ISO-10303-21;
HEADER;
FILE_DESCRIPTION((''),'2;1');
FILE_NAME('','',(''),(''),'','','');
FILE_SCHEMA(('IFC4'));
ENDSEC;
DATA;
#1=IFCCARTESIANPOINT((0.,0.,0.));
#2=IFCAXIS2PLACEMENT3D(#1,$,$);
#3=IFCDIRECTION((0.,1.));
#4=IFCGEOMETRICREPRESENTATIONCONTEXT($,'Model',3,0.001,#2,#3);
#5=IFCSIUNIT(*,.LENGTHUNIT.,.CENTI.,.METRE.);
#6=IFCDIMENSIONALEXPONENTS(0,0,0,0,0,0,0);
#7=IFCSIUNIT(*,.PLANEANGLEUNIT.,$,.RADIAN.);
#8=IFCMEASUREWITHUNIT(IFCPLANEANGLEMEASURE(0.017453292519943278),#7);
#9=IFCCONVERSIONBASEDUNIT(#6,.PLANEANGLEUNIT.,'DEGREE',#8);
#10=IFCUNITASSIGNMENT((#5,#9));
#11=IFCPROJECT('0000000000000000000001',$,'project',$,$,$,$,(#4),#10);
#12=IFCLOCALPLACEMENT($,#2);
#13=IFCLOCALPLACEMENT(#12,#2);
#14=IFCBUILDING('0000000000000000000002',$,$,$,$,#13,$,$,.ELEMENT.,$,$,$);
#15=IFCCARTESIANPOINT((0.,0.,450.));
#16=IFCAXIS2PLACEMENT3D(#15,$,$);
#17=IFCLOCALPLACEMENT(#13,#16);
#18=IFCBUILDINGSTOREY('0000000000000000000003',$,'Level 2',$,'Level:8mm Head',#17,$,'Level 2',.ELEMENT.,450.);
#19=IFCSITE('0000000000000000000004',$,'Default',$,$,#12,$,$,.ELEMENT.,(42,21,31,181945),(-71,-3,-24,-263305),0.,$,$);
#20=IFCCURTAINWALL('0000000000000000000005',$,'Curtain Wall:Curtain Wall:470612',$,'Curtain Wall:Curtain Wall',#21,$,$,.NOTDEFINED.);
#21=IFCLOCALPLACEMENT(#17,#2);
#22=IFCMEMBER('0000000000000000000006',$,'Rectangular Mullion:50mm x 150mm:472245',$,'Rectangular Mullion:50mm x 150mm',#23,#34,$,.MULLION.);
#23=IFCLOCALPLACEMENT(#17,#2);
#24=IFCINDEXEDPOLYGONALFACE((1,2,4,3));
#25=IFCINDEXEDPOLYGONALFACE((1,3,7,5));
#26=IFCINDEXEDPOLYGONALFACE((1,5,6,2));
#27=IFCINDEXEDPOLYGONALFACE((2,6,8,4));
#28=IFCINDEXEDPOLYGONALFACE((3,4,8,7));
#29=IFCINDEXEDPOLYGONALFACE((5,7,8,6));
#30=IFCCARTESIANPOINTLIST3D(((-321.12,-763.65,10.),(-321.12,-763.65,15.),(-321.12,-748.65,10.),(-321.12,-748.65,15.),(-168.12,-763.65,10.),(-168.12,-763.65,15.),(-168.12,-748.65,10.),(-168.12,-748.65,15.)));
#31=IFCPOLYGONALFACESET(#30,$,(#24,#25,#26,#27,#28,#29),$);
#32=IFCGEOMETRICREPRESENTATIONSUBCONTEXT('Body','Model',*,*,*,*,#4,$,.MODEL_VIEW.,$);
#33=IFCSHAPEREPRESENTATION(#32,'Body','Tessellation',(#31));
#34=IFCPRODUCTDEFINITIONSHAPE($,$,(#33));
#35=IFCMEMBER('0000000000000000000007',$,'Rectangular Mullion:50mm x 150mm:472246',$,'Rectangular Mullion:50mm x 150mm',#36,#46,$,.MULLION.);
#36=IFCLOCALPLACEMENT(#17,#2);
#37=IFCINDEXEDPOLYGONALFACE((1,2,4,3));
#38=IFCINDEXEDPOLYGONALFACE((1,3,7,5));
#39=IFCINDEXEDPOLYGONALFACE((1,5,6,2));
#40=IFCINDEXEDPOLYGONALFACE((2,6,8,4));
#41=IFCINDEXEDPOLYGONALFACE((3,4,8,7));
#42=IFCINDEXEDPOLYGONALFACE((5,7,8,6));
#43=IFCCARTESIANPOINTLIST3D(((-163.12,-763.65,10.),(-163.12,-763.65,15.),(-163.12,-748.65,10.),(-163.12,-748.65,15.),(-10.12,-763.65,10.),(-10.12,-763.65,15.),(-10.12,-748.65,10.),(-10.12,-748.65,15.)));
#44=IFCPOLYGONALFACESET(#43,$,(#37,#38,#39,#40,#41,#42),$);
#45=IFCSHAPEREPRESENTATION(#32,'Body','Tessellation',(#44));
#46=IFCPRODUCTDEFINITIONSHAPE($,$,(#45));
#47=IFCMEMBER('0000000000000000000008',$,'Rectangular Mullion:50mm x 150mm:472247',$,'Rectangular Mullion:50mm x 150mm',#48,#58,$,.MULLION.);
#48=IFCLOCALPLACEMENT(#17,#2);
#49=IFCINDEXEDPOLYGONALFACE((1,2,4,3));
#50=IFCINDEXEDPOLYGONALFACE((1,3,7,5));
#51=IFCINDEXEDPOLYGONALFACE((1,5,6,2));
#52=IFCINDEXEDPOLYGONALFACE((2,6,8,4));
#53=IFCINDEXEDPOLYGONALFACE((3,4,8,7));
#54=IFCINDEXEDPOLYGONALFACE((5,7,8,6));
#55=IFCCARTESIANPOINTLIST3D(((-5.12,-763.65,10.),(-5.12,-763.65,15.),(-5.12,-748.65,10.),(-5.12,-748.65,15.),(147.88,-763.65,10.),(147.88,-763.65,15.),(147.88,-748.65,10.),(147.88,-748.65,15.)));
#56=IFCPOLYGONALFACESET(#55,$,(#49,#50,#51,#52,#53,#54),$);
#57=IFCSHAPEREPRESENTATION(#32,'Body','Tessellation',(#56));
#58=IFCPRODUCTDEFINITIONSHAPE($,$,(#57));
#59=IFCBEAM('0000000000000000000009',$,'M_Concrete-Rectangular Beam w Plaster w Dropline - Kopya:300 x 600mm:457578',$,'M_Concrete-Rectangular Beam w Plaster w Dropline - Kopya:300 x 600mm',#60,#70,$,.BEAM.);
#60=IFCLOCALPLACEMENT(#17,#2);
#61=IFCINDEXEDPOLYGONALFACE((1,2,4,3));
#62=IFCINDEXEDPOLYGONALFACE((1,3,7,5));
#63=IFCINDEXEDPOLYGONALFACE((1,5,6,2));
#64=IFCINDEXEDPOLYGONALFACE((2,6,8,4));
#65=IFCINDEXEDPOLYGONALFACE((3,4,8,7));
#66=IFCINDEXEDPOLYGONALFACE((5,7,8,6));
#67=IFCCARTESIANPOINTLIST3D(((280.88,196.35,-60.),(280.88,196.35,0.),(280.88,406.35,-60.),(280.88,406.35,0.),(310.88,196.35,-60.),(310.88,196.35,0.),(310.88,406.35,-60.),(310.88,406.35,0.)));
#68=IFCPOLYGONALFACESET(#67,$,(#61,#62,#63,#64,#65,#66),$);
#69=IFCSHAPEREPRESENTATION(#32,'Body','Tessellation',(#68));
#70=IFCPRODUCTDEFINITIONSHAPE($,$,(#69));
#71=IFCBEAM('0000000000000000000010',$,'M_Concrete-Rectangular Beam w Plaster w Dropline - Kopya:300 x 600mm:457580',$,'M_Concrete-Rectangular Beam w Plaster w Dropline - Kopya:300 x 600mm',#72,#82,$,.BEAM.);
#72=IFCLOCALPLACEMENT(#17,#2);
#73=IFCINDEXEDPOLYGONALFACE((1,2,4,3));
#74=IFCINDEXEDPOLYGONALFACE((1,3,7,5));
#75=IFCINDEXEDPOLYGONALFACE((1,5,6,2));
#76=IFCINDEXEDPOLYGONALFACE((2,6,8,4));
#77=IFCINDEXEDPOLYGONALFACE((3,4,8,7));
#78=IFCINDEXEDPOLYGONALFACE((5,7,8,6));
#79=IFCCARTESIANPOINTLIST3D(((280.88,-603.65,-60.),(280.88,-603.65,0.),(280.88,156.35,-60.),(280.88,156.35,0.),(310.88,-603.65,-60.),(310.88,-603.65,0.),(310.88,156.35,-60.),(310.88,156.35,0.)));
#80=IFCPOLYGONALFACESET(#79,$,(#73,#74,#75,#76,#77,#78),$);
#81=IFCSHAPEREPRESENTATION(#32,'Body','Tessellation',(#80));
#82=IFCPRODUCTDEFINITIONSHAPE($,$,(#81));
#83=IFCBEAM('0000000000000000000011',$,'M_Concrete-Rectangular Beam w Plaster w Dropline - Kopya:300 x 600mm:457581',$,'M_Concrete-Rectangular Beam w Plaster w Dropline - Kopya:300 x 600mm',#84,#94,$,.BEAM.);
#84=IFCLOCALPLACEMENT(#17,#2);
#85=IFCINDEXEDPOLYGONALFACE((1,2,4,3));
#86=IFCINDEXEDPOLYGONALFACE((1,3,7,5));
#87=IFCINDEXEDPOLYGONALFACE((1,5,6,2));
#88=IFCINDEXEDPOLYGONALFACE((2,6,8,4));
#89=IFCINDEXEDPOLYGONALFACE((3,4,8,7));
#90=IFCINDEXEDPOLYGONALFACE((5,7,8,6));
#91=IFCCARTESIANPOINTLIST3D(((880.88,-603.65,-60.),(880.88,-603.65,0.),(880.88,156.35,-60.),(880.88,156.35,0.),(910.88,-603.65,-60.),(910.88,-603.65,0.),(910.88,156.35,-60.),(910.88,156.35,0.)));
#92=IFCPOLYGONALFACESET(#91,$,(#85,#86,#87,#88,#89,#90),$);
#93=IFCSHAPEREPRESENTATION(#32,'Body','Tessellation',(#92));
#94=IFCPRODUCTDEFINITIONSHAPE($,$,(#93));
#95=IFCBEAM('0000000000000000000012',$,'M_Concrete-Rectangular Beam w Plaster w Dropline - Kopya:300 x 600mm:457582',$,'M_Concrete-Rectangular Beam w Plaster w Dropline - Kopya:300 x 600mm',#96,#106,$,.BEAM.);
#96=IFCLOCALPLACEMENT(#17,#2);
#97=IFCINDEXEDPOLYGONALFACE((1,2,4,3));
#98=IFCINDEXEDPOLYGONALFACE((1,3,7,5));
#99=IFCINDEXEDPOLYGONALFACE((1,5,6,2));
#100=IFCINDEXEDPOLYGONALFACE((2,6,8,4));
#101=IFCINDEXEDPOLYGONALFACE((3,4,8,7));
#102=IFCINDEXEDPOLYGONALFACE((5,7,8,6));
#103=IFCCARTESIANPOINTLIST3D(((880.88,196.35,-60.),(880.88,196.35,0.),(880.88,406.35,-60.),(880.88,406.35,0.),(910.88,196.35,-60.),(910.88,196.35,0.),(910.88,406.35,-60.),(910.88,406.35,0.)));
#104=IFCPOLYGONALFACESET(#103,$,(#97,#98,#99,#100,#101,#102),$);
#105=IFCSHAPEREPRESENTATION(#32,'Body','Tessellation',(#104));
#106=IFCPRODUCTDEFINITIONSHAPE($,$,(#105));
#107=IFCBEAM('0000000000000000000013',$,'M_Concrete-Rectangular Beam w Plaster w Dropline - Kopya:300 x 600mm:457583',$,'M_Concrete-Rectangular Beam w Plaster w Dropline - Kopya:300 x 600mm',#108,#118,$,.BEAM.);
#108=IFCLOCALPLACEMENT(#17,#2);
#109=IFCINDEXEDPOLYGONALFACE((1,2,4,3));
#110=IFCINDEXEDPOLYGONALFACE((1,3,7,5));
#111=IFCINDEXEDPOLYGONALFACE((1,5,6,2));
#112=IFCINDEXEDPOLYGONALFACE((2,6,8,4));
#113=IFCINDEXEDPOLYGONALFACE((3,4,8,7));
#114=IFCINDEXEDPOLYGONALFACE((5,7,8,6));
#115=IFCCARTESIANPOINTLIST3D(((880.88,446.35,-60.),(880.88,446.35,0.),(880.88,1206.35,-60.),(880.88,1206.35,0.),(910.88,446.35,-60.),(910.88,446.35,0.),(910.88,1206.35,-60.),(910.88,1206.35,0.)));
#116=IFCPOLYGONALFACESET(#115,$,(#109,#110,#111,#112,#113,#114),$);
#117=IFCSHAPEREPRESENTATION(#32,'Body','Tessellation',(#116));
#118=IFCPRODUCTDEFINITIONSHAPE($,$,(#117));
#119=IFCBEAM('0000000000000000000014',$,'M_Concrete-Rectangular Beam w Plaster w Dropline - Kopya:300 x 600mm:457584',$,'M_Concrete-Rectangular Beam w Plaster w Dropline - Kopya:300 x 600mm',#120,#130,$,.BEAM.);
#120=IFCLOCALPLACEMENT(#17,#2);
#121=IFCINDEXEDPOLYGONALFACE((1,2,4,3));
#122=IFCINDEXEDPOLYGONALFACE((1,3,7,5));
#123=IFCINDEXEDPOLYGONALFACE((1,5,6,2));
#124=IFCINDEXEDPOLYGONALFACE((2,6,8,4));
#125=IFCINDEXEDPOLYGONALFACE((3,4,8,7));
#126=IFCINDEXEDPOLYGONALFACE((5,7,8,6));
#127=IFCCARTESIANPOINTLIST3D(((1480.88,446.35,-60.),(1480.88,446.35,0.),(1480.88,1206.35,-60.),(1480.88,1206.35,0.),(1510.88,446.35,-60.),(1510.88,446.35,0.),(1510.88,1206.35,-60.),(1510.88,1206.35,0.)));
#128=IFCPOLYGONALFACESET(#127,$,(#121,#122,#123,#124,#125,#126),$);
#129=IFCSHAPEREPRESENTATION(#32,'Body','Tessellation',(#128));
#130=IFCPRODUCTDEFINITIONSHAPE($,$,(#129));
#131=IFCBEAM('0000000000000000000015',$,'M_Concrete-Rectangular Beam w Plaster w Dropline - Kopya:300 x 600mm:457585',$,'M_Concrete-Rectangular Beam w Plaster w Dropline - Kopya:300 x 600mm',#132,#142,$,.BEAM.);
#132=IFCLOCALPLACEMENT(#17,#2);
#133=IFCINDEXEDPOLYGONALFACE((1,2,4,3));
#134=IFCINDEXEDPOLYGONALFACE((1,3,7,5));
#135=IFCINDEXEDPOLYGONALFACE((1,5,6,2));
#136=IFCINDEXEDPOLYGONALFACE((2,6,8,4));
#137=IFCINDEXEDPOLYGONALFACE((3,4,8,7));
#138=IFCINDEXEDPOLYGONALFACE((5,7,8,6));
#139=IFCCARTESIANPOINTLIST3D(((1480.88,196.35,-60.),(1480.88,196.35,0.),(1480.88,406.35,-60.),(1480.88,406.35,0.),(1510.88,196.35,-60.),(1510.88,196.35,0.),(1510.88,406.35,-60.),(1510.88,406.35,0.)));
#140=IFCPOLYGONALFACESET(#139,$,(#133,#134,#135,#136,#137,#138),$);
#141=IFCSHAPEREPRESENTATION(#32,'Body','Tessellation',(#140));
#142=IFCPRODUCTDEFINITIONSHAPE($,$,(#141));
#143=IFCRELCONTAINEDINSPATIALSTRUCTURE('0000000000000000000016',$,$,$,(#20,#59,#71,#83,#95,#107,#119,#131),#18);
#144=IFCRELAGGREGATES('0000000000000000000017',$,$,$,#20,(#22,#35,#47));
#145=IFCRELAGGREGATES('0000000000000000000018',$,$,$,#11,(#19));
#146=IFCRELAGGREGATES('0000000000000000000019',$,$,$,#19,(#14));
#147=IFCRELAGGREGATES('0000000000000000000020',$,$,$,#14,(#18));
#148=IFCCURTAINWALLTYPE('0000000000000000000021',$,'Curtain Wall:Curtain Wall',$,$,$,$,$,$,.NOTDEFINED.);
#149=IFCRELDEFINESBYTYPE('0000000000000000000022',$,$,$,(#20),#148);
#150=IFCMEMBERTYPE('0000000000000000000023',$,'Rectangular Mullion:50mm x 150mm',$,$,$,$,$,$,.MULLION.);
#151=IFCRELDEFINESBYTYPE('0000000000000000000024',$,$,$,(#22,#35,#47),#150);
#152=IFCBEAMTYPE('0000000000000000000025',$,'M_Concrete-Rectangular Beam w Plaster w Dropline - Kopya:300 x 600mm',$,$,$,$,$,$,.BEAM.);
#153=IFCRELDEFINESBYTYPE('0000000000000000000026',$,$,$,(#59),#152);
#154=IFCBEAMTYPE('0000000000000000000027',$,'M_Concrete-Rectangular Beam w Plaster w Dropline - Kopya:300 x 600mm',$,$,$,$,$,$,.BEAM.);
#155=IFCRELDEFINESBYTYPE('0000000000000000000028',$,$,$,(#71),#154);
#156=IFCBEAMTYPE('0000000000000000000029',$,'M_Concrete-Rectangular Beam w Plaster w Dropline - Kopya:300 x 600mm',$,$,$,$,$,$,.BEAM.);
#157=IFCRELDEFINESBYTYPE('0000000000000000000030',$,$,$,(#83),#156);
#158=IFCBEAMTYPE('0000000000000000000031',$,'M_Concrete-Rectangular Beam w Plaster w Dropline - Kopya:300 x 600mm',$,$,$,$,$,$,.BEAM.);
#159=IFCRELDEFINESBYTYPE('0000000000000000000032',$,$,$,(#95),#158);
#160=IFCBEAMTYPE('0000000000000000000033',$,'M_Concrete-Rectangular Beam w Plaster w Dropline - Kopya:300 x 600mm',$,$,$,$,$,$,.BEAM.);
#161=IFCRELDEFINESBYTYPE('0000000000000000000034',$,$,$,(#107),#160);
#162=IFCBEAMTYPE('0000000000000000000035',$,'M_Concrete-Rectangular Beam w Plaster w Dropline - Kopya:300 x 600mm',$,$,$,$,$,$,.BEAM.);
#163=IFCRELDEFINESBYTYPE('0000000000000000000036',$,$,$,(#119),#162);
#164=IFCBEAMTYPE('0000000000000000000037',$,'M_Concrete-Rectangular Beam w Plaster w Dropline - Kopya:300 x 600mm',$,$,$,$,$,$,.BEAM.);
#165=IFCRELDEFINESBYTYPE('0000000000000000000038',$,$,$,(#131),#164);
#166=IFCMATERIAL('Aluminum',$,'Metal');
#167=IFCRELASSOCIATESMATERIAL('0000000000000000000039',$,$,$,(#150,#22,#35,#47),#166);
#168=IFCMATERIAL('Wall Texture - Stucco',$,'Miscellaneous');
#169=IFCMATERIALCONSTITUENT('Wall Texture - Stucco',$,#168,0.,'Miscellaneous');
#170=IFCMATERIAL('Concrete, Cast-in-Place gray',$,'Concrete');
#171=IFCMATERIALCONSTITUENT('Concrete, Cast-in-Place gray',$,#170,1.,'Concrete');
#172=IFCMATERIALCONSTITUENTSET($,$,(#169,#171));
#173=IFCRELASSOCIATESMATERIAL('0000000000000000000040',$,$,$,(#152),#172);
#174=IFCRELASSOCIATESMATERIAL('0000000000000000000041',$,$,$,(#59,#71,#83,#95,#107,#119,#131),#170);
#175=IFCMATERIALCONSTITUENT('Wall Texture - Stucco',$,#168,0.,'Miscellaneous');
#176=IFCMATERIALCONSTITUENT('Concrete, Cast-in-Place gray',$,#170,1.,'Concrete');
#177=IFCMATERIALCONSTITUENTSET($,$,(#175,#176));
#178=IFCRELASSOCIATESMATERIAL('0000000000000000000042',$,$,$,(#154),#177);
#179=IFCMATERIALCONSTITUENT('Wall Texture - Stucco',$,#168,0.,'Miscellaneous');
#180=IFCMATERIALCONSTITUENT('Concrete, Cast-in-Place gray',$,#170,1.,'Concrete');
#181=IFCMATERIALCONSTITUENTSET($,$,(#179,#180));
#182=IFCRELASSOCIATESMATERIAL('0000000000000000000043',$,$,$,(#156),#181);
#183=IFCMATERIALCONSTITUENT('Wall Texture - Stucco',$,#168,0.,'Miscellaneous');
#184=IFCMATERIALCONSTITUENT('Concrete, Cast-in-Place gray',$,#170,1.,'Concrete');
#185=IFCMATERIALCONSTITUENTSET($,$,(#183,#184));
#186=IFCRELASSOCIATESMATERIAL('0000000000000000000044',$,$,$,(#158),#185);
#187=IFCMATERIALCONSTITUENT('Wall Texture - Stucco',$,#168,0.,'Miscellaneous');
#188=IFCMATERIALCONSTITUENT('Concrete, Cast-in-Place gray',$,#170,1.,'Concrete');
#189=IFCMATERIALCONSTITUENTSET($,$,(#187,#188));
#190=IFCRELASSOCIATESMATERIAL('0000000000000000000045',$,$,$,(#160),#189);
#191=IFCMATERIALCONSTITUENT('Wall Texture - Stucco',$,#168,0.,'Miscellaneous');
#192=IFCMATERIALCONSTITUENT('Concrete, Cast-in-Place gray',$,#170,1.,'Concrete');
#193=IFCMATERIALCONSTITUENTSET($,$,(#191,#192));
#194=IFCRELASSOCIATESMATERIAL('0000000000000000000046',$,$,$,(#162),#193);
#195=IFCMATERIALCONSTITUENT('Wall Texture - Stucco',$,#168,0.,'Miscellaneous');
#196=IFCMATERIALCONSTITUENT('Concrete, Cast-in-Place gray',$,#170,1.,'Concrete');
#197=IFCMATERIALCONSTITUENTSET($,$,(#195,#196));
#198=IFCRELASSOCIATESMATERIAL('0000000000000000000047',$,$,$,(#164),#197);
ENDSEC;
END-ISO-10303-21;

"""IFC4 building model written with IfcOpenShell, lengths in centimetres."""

from ifc_helpers import new_model, entity, si_unit, converted_unit, direction, frame, origin, place, context, subcontext, project, spatial, indexed_curve, outline, extrude, source, transform, mapped, material, constituent, constituent_set, type_object, type_shapes, element, aggregate, save


model = new_model("IFC4")

# Units and contexts
model_context = context("Model", 3, precision=0.001, world=origin(), true_north=direction((0.0, 1.0)))
body_context = subcontext(model_context, "Body", "Model", "MODEL_VIEW")
ifc_project = project(units=[si_unit("LENGTHUNIT", "METRE", prefix="CENTI"), converted_unit("PLANEANGLEUNIT", "DEGREE", entity("IfcPlaneAngleMeasure", 0.017453292519943278), si_unit("PLANEANGLEUNIT", "RADIAN"), dimensions=[0, 0, 0, 0, 0, 0, 0])], contexts=[model_context])

# Site, building, storey
site_placement = place(None, origin())
site = spatial("IfcSite", under=ifc_project, at=site_placement, Name="Default", CompositionType="ELEMENT", RefLatitude=(42, 21, 31, 181945), RefLongitude=(-71, -3, -24, -263305), RefElevation=0.0)
building_placement = place(site_placement, origin())
building = spatial("IfcBuilding", under=site, at=building_placement, CompositionType="ELEMENT")
storey_placement = place(building_placement, frame((0.0, 0.0, 450.0)))
storey = spatial("IfcBuildingStorey", under=building, at=storey_placement, Name="Level 2", ObjectType="Level:8mm Head", LongName="Level 2", CompositionType="ELEMENT", Elevation=450.0)

# Curtain wall, members
curtain_wall_type = type_object("IfcCurtainWallType", Name="Curtain Wall:Curtain Wall", PredefinedType="NOTDEFINED")
curtain_wall_placement = place(storey_placement, frame((0.0, 0.0, -450.0)))
curtain_wall = element("IfcCurtainWall", 1, at=curtain_wall_placement, inside=storey, type_object=curtain_wall_type, Name="Curtain Wall:Curtain Wall:470612", ObjectType="Curtain Wall:Curtain Wall", PredefinedType="NOTDEFINED")
ifc_material_1 = material(Name="Aluminum", Category="Metal")
member_type_1 = type_object("IfcMemberType", Name="Rectangular Mullion:50mm x 150mm", PredefinedType="MULLION", material=ifc_material_1)
shared_shape_1 = source(origin(), body_context, "Body", "SweptSolid", [
    extrude(outline(indexed_curve([(-2.5, -7.5), (2.5, -7.5), (2.5, 7.5), (-2.5, 7.5), (-2.5, -7.5)], self_intersect=False)), frame((-2.5, 0.0, -153.0), z_axis=(0.0, 0.0, 1.0), x_axis=(-1.0, 0.0, 0.0)), (0.0, 0.0, 1.0), 153.0),
])
type_shapes(member_type_1, [shared_shape_1])
member_1_placement = place(curtain_wall_placement, frame((-321.12, -756.15, 460.0), z_axis=(-1.0, 0.0, 0.0), x_axis=(0.0, 0.0, -1.0)))
member_1 = element("IfcMember", 2, at=member_1_placement, type_object=member_type_1, material=ifc_material_1, Name="Rectangular Mullion:50mm x 150mm:472245", ObjectType="Rectangular Mullion:50mm x 150mm", PredefinedType="MULLION", context=body_context, shape_type="MappedRepresentation", body=[
    mapped(shared_shape_1, transform((0.0, 0.0, 0.0), scale=1.0)),
])
member_2_placement = place(curtain_wall_placement, frame((-163.12, -756.15, 460.0), z_axis=(-1.0, 0.0, 0.0), x_axis=(0.0, 0.0, -1.0)))
member_2 = element("IfcMember", 3, at=member_2_placement, type_object=member_type_1, material=ifc_material_1, Name="Rectangular Mullion:50mm x 150mm:472246", ObjectType="Rectangular Mullion:50mm x 150mm", PredefinedType="MULLION", context=body_context, shape_type="MappedRepresentation", body=[
    mapped(shared_shape_1, transform((0.0, 0.0, 0.0), scale=1.0)),
])
member_3_placement = place(curtain_wall_placement, frame((-5.12, -756.15, 460.0), z_axis=(-1.0, 0.0, 0.0), x_axis=(0.0, 0.0, -1.0)))
member_3 = element("IfcMember", 4, at=member_3_placement, type_object=member_type_1, material=ifc_material_1, Name="Rectangular Mullion:50mm x 150mm:472247", ObjectType="Rectangular Mullion:50mm x 150mm", PredefinedType="MULLION", context=body_context, shape_type="MappedRepresentation", body=[
    mapped(shared_shape_1, transform((0.0, 0.0, 0.0), scale=1.0)),
])

# Beams
ifc_material_2 = material(Name="Concrete, Cast-in-Place gray", Category="Concrete")
ifc_material_3 = material(Name="Wall Texture - Stucco", Category="Miscellaneous")
ifc_constituent_1 = constituent(ifc_material_3, Name="Wall Texture - Stucco", Category="Miscellaneous", fraction=0.0)
ifc_constituent_2 = constituent(ifc_material_2, Name="Concrete, Cast-in-Place gray", Category="Concrete", fraction=1.0)
ifc_constituent_set_1 = constituent_set(constituents=[ifc_constituent_1, ifc_constituent_2])
beam_type_1 = type_object("IfcBeamType", Name="M_Concrete-Rectangular Beam w Plaster w Dropline - Kopya:300 x 600mm", PredefinedType="BEAM", material=ifc_constituent_set_1)
shared_shape_2 = source(origin(), body_context, "Body", "SweptSolid", [
    extrude(outline(indexed_curve([(-15.0, -30.0), (15.0, -30.0), (15.0, 30.0), (-15.0, 30.0), (-15.0, -30.0)], self_intersect=False)), frame((295.88, 406.35, 420.0), z_axis=(0.0, -1.0, 0.0), x_axis=(-1.0, 0.0, 0.0)), (0.0, 0.0, 1.0), 210.0),
])
type_shapes(beam_type_1, [shared_shape_2])
beam_1_placement = place(storey_placement, frame((0.0, 0.0, -450.0)))
element("IfcBeam", 5, at=beam_1_placement, inside=storey, type_object=beam_type_1, material=ifc_material_2, Name="M_Concrete-Rectangular Beam w Plaster w Dropline - Kopya:300 x 600mm:457578", ObjectType="M_Concrete-Rectangular Beam w Plaster w Dropline - Kopya:300 x 600mm", PredefinedType="BEAM", context=body_context, shape_type="MappedRepresentation", body=[
    mapped(shared_shape_2, transform((0.0, 0.0, 0.0), scale=1.0)),
])
ifc_constituent_3 = constituent(ifc_material_3, Name="Wall Texture - Stucco", Category="Miscellaneous", fraction=0.0)
ifc_constituent_4 = constituent(ifc_material_2, Name="Concrete, Cast-in-Place gray", Category="Concrete", fraction=1.0)
ifc_constituent_set_2 = constituent_set(constituents=[ifc_constituent_3, ifc_constituent_4])
beam_type_2 = type_object("IfcBeamType", Name="M_Concrete-Rectangular Beam w Plaster w Dropline - Kopya:300 x 600mm", PredefinedType="BEAM", material=ifc_constituent_set_2)
shared_shape_3 = source(origin(), body_context, "Body", "SweptSolid", [
    extrude(outline(indexed_curve([(-15.0, -30.0), (15.0, -30.0), (15.0, 30.0), (-15.0, 30.0), (-15.0, -30.0)], self_intersect=False)), frame((295.88, 156.35, 420.0), z_axis=(0.0, -1.0, 0.0), x_axis=(-1.0, 0.0, 0.0)), (0.0, 0.0, 1.0), 760.0),
])
type_shapes(beam_type_2, [shared_shape_3])
beam_2_placement = place(storey_placement, frame((0.0, 0.0, -450.0)))
element("IfcBeam", 6, at=beam_2_placement, inside=storey, type_object=beam_type_2, material=ifc_material_2, Name="M_Concrete-Rectangular Beam w Plaster w Dropline - Kopya:300 x 600mm:457580", ObjectType="M_Concrete-Rectangular Beam w Plaster w Dropline - Kopya:300 x 600mm", PredefinedType="BEAM", context=body_context, shape_type="MappedRepresentation", body=[
    mapped(shared_shape_3, transform((0.0, 0.0, 0.0), scale=1.0)),
])
ifc_constituent_5 = constituent(ifc_material_3, Name="Wall Texture - Stucco", Category="Miscellaneous", fraction=0.0)
ifc_constituent_6 = constituent(ifc_material_2, Name="Concrete, Cast-in-Place gray", Category="Concrete", fraction=1.0)
ifc_constituent_set_3 = constituent_set(constituents=[ifc_constituent_5, ifc_constituent_6])
beam_type_3 = type_object("IfcBeamType", Name="M_Concrete-Rectangular Beam w Plaster w Dropline - Kopya:300 x 600mm", PredefinedType="BEAM", material=ifc_constituent_set_3)
shared_shape_4 = source(origin(), body_context, "Body", "SweptSolid", [
    extrude(outline(indexed_curve([(-15.0, -30.0), (15.0, -30.0), (15.0, 30.0), (-15.0, 30.0), (-15.0, -30.0)], self_intersect=False)), frame((895.88, -603.65, 420.0), z_axis=(0.0, 1.0, 0.0), x_axis=(-1.0, 0.0, 0.0)), (0.0, 0.0, 1.0), 760.0),
])
type_shapes(beam_type_3, [shared_shape_4])
beam_3_placement = place(storey_placement, frame((0.0, 0.0, -450.0)))
element("IfcBeam", 7, at=beam_3_placement, inside=storey, type_object=beam_type_3, material=ifc_material_2, Name="M_Concrete-Rectangular Beam w Plaster w Dropline - Kopya:300 x 600mm:457581", ObjectType="M_Concrete-Rectangular Beam w Plaster w Dropline - Kopya:300 x 600mm", PredefinedType="BEAM", context=body_context, shape_type="MappedRepresentation", body=[
    mapped(shared_shape_4, transform((0.0, 0.0, 0.0), scale=1.0)),
])
ifc_constituent_7 = constituent(ifc_material_3, Name="Wall Texture - Stucco", Category="Miscellaneous", fraction=0.0)
ifc_constituent_8 = constituent(ifc_material_2, Name="Concrete, Cast-in-Place gray", Category="Concrete", fraction=1.0)
ifc_constituent_set_4 = constituent_set(constituents=[ifc_constituent_7, ifc_constituent_8])
beam_type_4 = type_object("IfcBeamType", Name="M_Concrete-Rectangular Beam w Plaster w Dropline - Kopya:300 x 600mm", PredefinedType="BEAM", material=ifc_constituent_set_4)
shared_shape_5 = source(origin(), body_context, "Body", "SweptSolid", [
    extrude(outline(indexed_curve([(-15.0, -30.0), (15.0, -30.0), (15.0, 30.0), (-15.0, 30.0), (-15.0, -30.0)], self_intersect=False)), frame((895.88, 196.35, 420.0), z_axis=(0.0, 1.0, 0.0), x_axis=(-1.0, 0.0, 0.0)), (0.0, 0.0, 1.0), 210.0),
])
type_shapes(beam_type_4, [shared_shape_5])
beam_4_placement = place(storey_placement, frame((0.0, 0.0, -450.0)))
element("IfcBeam", 8, at=beam_4_placement, inside=storey, type_object=beam_type_4, material=ifc_material_2, Name="M_Concrete-Rectangular Beam w Plaster w Dropline - Kopya:300 x 600mm:457582", ObjectType="M_Concrete-Rectangular Beam w Plaster w Dropline - Kopya:300 x 600mm", PredefinedType="BEAM", context=body_context, shape_type="MappedRepresentation", body=[
    mapped(shared_shape_5, transform((0.0, 0.0, 0.0), scale=1.0)),
])
ifc_constituent_9 = constituent(ifc_material_3, Name="Wall Texture - Stucco", Category="Miscellaneous", fraction=0.0)
ifc_constituent_10 = constituent(ifc_material_2, Name="Concrete, Cast-in-Place gray", Category="Concrete", fraction=1.0)
ifc_constituent_set_5 = constituent_set(constituents=[ifc_constituent_9, ifc_constituent_10])
beam_type_5 = type_object("IfcBeamType", Name="M_Concrete-Rectangular Beam w Plaster w Dropline - Kopya:300 x 600mm", PredefinedType="BEAM", material=ifc_constituent_set_5)
shared_shape_6 = source(origin(), body_context, "Body", "SweptSolid", [
    extrude(outline(indexed_curve([(-15.0, -30.0), (15.0, -30.0), (15.0, 30.0), (-15.0, 30.0), (-15.0, -30.0)], self_intersect=False)), frame((895.88, 446.35, 420.0), z_axis=(0.0, 1.0, 0.0), x_axis=(-1.0, 0.0, 0.0)), (0.0, 0.0, 1.0), 760.0),
])
type_shapes(beam_type_5, [shared_shape_6])
beam_5_placement = place(storey_placement, frame((0.0, 0.0, -450.0)))
element("IfcBeam", 9, at=beam_5_placement, inside=storey, type_object=beam_type_5, material=ifc_material_2, Name="M_Concrete-Rectangular Beam w Plaster w Dropline - Kopya:300 x 600mm:457583", ObjectType="M_Concrete-Rectangular Beam w Plaster w Dropline - Kopya:300 x 600mm", PredefinedType="BEAM", context=body_context, shape_type="MappedRepresentation", body=[
    mapped(shared_shape_6, transform((0.0, 0.0, 0.0), scale=1.0)),
])
ifc_constituent_11 = constituent(ifc_material_3, Name="Wall Texture - Stucco", Category="Miscellaneous", fraction=0.0)
ifc_constituent_12 = constituent(ifc_material_2, Name="Concrete, Cast-in-Place gray", Category="Concrete", fraction=1.0)
ifc_constituent_set_6 = constituent_set(constituents=[ifc_constituent_11, ifc_constituent_12])
beam_type_6 = type_object("IfcBeamType", Name="M_Concrete-Rectangular Beam w Plaster w Dropline - Kopya:300 x 600mm", PredefinedType="BEAM", material=ifc_constituent_set_6)
shared_shape_7 = source(origin(), body_context, "Body", "SweptSolid", [
    extrude(outline(indexed_curve([(-15.0, -30.0), (15.0, -30.0), (15.0, 30.0), (-15.0, 30.0), (-15.0, -30.0)], self_intersect=False)), frame((1495.88, 1206.35, 420.0), z_axis=(0.0, -1.0, 0.0), x_axis=(-1.0, 0.0, 0.0)), (0.0, 0.0, 1.0), 760.0),
])
type_shapes(beam_type_6, [shared_shape_7])
beam_6_placement = place(storey_placement, frame((0.0, 0.0, -450.0)))
element("IfcBeam", 10, at=beam_6_placement, inside=storey, type_object=beam_type_6, material=ifc_material_2, Name="M_Concrete-Rectangular Beam w Plaster w Dropline - Kopya:300 x 600mm:457584", ObjectType="M_Concrete-Rectangular Beam w Plaster w Dropline - Kopya:300 x 600mm", PredefinedType="BEAM", context=body_context, shape_type="MappedRepresentation", body=[
    mapped(shared_shape_7, transform((0.0, 0.0, 0.0), scale=1.0)),
])
ifc_constituent_13 = constituent(ifc_material_3, Name="Wall Texture - Stucco", Category="Miscellaneous", fraction=0.0)
ifc_constituent_14 = constituent(ifc_material_2, Name="Concrete, Cast-in-Place gray", Category="Concrete", fraction=1.0)
ifc_constituent_set_7 = constituent_set(constituents=[ifc_constituent_13, ifc_constituent_14])
beam_type_7 = type_object("IfcBeamType", Name="M_Concrete-Rectangular Beam w Plaster w Dropline - Kopya:300 x 600mm", PredefinedType="BEAM", material=ifc_constituent_set_7)
shared_shape_8 = source(origin(), body_context, "Body", "SweptSolid", [
    extrude(outline(indexed_curve([(-15.0, -30.0), (15.0, -30.0), (15.0, 30.0), (-15.0, 30.0), (-15.0, -30.0)], self_intersect=False)), frame((1495.88, 406.35, 420.0), z_axis=(0.0, -1.0, 0.0), x_axis=(-1.0, 0.0, 0.0)), (0.0, 0.0, 1.0), 210.0),
])
type_shapes(beam_type_7, [shared_shape_8])
beam_7_placement = place(storey_placement, frame((0.0, 0.0, -450.0)))
element("IfcBeam", 11, at=beam_7_placement, inside=storey, type_object=beam_type_7, material=ifc_material_2, Name="M_Concrete-Rectangular Beam w Plaster w Dropline - Kopya:300 x 600mm:457585", ObjectType="M_Concrete-Rectangular Beam w Plaster w Dropline - Kopya:300 x 600mm", PredefinedType="BEAM", context=body_context, shape_type="MappedRepresentation", body=[
    mapped(shared_shape_8, transform((0.0, 0.0, 0.0), scale=1.0)),
])

aggregate(curtain_wall, [member_1, member_2, member_3])

save(model, "model.ifc")
